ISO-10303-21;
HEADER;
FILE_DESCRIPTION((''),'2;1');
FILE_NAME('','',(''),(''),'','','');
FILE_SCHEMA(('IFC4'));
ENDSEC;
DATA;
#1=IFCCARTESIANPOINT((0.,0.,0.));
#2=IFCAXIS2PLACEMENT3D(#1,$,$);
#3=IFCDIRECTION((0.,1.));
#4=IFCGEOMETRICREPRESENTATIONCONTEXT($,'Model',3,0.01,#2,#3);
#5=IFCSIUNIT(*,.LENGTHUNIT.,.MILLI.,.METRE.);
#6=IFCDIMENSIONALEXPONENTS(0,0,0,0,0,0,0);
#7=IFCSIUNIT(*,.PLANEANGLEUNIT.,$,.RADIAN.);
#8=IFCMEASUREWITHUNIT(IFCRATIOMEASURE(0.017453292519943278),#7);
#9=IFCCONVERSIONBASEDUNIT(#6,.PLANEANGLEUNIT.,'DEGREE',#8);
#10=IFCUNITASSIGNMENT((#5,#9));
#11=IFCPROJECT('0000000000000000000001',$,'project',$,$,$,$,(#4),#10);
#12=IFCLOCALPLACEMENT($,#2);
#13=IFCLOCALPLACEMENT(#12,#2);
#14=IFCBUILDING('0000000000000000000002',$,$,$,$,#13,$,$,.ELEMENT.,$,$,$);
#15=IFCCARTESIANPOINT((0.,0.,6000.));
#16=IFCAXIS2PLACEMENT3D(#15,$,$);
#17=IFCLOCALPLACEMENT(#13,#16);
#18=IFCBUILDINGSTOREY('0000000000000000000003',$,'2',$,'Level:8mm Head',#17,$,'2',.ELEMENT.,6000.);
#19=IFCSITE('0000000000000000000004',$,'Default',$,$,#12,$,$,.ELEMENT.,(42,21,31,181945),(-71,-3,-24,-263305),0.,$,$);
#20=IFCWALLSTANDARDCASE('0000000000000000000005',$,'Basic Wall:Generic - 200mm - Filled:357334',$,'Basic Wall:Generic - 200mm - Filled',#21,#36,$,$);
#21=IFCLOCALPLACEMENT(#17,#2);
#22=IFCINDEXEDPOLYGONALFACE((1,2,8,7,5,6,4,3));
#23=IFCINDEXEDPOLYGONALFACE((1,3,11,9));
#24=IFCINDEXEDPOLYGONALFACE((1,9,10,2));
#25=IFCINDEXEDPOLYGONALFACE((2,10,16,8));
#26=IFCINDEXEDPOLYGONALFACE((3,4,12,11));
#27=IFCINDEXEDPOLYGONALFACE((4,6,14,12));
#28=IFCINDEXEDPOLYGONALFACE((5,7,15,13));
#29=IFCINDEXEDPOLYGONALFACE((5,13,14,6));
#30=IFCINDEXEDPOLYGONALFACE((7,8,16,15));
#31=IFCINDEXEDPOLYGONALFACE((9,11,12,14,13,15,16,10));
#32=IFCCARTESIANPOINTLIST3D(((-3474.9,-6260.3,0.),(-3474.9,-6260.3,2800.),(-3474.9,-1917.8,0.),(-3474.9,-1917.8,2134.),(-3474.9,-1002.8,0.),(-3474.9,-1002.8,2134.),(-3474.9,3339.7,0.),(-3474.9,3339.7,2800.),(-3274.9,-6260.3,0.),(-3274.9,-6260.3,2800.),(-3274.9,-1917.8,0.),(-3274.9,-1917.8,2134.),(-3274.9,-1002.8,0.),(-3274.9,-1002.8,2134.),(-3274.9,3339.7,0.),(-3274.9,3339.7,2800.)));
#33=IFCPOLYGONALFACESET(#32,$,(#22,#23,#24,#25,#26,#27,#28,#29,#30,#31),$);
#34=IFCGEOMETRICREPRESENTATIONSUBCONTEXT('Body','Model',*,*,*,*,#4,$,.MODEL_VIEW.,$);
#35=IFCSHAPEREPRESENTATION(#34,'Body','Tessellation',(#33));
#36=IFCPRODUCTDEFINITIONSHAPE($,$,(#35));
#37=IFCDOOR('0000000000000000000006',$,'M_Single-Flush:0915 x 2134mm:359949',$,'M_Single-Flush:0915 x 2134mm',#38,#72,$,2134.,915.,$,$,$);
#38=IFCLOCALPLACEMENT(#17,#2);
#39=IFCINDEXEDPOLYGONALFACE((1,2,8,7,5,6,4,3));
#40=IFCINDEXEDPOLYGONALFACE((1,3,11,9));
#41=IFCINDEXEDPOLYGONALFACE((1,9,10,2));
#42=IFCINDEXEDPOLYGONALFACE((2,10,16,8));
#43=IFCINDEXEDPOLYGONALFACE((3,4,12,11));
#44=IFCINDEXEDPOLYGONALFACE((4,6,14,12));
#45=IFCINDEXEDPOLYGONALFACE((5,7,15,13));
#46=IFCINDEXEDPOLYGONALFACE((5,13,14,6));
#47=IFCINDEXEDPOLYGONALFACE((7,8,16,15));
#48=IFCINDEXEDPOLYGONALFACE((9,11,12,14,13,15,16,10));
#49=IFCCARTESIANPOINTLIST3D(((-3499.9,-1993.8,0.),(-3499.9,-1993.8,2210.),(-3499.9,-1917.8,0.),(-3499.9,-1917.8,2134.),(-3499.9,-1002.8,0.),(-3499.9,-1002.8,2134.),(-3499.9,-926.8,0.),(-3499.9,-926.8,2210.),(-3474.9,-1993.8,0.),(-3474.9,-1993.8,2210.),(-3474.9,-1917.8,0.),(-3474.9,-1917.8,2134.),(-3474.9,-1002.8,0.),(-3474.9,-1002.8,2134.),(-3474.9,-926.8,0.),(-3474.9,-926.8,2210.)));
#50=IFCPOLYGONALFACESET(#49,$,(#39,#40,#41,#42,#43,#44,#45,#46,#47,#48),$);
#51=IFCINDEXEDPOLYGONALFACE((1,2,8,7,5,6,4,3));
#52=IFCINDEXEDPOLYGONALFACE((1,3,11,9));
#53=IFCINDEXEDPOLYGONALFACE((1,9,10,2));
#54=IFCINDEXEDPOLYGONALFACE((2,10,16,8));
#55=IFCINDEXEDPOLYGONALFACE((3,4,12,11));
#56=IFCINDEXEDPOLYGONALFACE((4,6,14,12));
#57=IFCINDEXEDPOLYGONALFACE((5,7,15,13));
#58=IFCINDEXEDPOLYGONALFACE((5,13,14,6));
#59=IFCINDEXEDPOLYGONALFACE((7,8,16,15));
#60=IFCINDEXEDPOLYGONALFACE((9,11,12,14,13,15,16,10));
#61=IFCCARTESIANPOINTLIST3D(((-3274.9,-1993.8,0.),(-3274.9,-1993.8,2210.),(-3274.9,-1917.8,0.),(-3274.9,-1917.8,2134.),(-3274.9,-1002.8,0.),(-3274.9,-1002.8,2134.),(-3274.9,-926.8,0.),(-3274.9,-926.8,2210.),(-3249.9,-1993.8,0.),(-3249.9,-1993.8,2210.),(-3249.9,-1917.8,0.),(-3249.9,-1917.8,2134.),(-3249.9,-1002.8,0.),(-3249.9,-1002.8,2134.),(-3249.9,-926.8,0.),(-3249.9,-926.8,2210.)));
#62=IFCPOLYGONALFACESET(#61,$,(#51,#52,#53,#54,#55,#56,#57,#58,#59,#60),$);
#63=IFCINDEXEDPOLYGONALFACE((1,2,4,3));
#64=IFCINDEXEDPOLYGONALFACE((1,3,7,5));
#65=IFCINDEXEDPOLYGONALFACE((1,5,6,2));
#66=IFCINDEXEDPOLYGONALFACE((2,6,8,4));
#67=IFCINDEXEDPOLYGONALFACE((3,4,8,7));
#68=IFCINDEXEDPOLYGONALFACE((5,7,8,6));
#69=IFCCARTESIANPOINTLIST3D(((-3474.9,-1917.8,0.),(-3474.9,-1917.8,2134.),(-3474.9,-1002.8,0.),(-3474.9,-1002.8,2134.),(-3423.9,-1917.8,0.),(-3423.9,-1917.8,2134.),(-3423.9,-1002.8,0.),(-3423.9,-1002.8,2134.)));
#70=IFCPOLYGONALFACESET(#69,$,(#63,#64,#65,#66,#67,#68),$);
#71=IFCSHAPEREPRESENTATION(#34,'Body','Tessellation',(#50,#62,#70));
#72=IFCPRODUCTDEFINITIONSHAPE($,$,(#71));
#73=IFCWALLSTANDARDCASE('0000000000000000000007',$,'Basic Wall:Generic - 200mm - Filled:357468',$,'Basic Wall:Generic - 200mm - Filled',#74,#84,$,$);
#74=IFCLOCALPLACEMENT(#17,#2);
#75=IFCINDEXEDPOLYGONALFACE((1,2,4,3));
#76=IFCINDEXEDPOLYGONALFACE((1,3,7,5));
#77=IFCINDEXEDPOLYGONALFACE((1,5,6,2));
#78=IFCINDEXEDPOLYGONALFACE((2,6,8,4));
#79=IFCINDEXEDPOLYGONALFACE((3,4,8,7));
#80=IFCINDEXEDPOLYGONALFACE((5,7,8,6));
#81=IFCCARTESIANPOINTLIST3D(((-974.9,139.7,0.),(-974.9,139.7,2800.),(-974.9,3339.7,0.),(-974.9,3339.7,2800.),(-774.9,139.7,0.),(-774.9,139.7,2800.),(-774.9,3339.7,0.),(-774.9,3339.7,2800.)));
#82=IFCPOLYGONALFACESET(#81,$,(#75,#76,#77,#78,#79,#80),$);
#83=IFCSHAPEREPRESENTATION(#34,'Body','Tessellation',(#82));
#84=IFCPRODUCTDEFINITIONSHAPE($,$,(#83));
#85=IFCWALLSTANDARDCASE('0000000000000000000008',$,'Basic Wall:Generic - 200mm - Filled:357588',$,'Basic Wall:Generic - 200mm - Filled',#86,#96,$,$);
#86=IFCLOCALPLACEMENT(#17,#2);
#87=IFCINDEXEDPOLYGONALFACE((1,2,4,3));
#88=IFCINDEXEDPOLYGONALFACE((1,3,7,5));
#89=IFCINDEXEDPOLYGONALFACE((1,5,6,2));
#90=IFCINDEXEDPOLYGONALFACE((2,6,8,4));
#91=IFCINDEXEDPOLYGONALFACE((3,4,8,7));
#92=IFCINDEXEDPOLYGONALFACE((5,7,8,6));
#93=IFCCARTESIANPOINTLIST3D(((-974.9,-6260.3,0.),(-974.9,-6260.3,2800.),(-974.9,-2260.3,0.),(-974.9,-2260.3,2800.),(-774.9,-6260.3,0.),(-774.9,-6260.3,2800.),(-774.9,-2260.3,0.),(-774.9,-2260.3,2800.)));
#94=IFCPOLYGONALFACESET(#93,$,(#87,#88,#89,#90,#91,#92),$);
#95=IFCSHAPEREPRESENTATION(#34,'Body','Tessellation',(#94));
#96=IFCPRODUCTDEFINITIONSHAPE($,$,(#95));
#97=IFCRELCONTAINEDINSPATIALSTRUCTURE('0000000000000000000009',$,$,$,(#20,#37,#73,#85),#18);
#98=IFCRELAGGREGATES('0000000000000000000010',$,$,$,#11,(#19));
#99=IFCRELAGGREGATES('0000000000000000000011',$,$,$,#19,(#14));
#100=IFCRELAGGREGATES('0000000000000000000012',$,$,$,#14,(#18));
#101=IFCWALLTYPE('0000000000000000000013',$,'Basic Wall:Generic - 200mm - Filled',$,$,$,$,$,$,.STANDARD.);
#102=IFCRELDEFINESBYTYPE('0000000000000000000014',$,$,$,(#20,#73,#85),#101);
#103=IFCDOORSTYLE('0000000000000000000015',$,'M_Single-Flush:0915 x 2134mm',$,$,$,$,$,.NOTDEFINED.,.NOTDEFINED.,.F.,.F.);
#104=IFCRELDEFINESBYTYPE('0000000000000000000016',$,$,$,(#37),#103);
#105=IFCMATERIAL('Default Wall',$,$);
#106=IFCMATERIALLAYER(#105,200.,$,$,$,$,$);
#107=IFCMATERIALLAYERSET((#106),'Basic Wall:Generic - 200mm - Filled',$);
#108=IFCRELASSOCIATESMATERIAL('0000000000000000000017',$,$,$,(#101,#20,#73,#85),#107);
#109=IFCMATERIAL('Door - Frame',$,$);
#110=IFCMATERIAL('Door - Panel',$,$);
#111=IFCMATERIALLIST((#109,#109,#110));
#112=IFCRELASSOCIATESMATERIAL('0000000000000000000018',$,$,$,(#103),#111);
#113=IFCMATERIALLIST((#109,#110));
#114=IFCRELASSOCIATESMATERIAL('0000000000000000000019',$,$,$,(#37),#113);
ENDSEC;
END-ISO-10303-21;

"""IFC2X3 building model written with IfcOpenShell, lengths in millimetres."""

from ifc_helpers import new_model, entity, si_unit, converted_unit, direction, frame, frame_2d, origin, place, context, subcontext, project, spatial, polyline, rectangle, outline, extrude, source, transform, mapped, material, material_list, layer, layer_set, layer_usage, type_object, type_shapes, element, fill, save


model = new_model("IFC2X3")

# Units and contexts
model_context = context("Model", 3, precision=0.01, world=origin(), true_north=direction((0.0, 1.0)))
body_context = subcontext(model_context, "Body", "Model", "MODEL_VIEW")
ifc_project = project(units=[si_unit("LENGTHUNIT", "METRE", prefix="MILLI"), converted_unit("PLANEANGLEUNIT", "DEGREE", entity("IfcRatioMeasure", 0.017453292519943278), si_unit("PLANEANGLEUNIT", "RADIAN"), dimensions=[0, 0, 0, 0, 0, 0, 0])], contexts=[model_context])

# Site, building, storey
site_placement = place(None, origin())
site = spatial("IfcSite", under=ifc_project, at=site_placement, Name="Default", CompositionType="ELEMENT", RefLatitude=(42, 21, 31, 181945), RefLongitude=(-71, -3, -24, -263305), RefElevation=0.0)
building_placement = place(site_placement, origin())
building = spatial("IfcBuilding", under=site, at=building_placement, CompositionType="ELEMENT")
storey_placement = place(building_placement, frame((0.0, 0.0, 6000.0)))
storey = spatial("IfcBuildingStorey", under=building, at=storey_placement, Name="2", ObjectType="Level:8mm Head", LongName="2", CompositionType="ELEMENT", Elevation=6000.0)

# Wall, opening, door
ifc_material_1 = material(Name="Default Wall")
ifc_layer_1 = layer(ifc_material_1, 200.0)
ifc_layer_set_1 = layer_set([ifc_layer_1], Name="Basic Wall:Generic - 200mm - Filled")
ifc_layer_usage_1 = layer_usage(ifc_layer_set_1, "AXIS2", "NEGATIVE", 100.0)
wall_type_1 = type_object("IfcWallType", Name="Basic Wall:Generic - 200mm - Filled", PredefinedType="STANDARD", material=ifc_layer_set_1)
wall_1_placement = place(storey_placement, frame((-3374.9, 3339.7, 0.0), z_axis=(0.0, 0.0, 1.0), x_axis=(0.0, -1.0, 0.0)))
wall_1 = element("IfcWallStandardCase", 1, at=wall_1_placement, inside=storey, type_object=wall_type_1, material=ifc_layer_usage_1, Name="Basic Wall:Generic - 200mm - Filled:357334", ObjectType="Basic Wall:Generic - 200mm - Filled", context=body_context, shape_type="SweptSolid", body=[
    extrude(rectangle(XDim=9600.0, YDim=200.0, at=frame_2d((4800.0, 0.0), x_axis=(1.0, 0.0))), origin(), (0.0, 0.0, 1.0), 2800.0),
])
opening_1_placement = place(wall_1_placement, frame((5257.5, 100.0, 0.0)))
opening_1 = element("IfcOpeningElement", 2, at=opening_1_placement, cuts=wall_1, ObjectType="Opening", context=body_context, shape_type="SweptSolid", body=[
    extrude(rectangle(XDim=915.0, YDim=2134.0, at=frame_2d((1067.0, 457.5), x_axis=(0.0, 1.0))), frame((0.0, 0.0, 0.0), z_axis=(0.0, -1.0, 0.0), x_axis=(0.0, 0.0, 1.0)), (0.0, 0.0, 1.0), 200.0),
])
ifc_material_2 = material(Name="Door - Frame")
ifc_material_3 = material(Name="Door - Panel")
ifc_material_list_1 = material_list([ifc_material_2, ifc_material_3])
ifc_material_list_2 = material_list([ifc_material_2, ifc_material_2, ifc_material_3])
door_style_1 = type_object("IfcDoorStyle", Name="M_Single-Flush:0915 x 2134mm", ConstructionType="NOTDEFINED", OperationType="NOTDEFINED", ParameterTakesPrecedence=False, Sizeable=False, material=ifc_material_list_2)
shared_shape_1 = source(origin(), body_context, "Body", "SweptSolid", [
    extrude(outline(polyline([(-533.5, -1124.0), (533.5, -1124.0), (533.5, 1086.0), (457.5, 1086.0), (457.5, -1048.0), (-457.5, -1048.0), (-457.5, 1086.0), (-533.5, 1086.0), (-533.5, -1124.0)])), frame((457.5, 200.0, 1086.0), z_axis=(0.0, 1.0, 0.0), x_axis=(1.0, 0.0, 0.0)), (0.0, 0.0, 1.0), 25.0),
    extrude(outline(polyline([(-1124.0, -533.5), (1086.0, -533.5), (1086.0, -457.5), (-1048.0, -457.5), (-1048.0, 457.5), (1086.0, 457.5), (1086.0, 533.5), (-1124.0, 533.5), (-1124.0, -533.5)])), frame((457.5, -25.0, 1086.0), z_axis=(0.0, 1.0, 0.0), x_axis=(0.0, 0.0, -1.0)), (0.0, 0.0, 1.0), 25.0),
    extrude(rectangle(XDim=51.0, YDim=915.0, at=frame_2d((0.0, 0.0), x_axis=(1.0, 0.0))), frame((457.5, 174.5, 0.0), z_axis=(0.0, 0.0, 1.0), x_axis=(0.0, 1.0, 0.0)), (0.0, 0.0, 1.0), 2134.0),
])
type_shapes(door_style_1, [shared_shape_1])
door_1_placement = place(opening_1_placement, frame((0.0, 0.0, 0.0), z_axis=(0.0, 0.0, 1.0), x_axis=(-1.0, 0.0, 0.0)))
door_1 = element("IfcDoor", 3, at=door_1_placement, inside=storey, type_object=door_style_1, material=ifc_material_list_1, Name="M_Single-Flush:0915 x 2134mm:359949", ObjectType="M_Single-Flush:0915 x 2134mm", OverallHeight=2134.0, OverallWidth=915.0, context=body_context, shape_type="MappedRepresentation", body=[
    mapped(shared_shape_1, transform((0.0, 0.0, 0.0), scale=1.0)),
])
fill(opening_1, door_1)

# Walls
ifc_layer_usage_2 = layer_usage(ifc_layer_set_1, "AXIS2", "NEGATIVE", 100.0)
wall_2_placement = place(storey_placement, frame((-874.9, 3339.7, 0.0), z_axis=(0.0, 0.0, 1.0), x_axis=(0.0, -1.0, 0.0)))
element("IfcWallStandardCase", 4, at=wall_2_placement, inside=storey, type_object=wall_type_1, material=ifc_layer_usage_2, Name="Basic Wall:Generic - 200mm - Filled:357468", ObjectType="Basic Wall:Generic - 200mm - Filled", context=body_context, shape_type="SweptSolid", body=[
    extrude(rectangle(XDim=3200.0, YDim=200.0, at=frame_2d((1600.0, 0.0), x_axis=(-1.0, 0.0))), origin(), (0.0, 0.0, 1.0), 2800.0),
])
ifc_layer_usage_3 = layer_usage(ifc_layer_set_1, "AXIS2", "NEGATIVE", 100.0)
wall_3_placement = place(storey_placement, frame((-874.9, -2260.3, 0.0), z_axis=(0.0, 0.0, 1.0), x_axis=(0.0, -1.0, 0.0)))
element("IfcWallStandardCase", 5, at=wall_3_placement, inside=storey, type_object=wall_type_1, material=ifc_layer_usage_3, Name="Basic Wall:Generic - 200mm - Filled:357588", ObjectType="Basic Wall:Generic - 200mm - Filled", context=body_context, shape_type="SweptSolid", body=[
    extrude(rectangle(XDim=4000.0, YDim=200.0, at=frame_2d((2000.0, 0.0), x_axis=(-1.0, 0.0))), origin(), (0.0, 0.0, 1.0), 2800.0),
])

save(model, "model.ifc")
